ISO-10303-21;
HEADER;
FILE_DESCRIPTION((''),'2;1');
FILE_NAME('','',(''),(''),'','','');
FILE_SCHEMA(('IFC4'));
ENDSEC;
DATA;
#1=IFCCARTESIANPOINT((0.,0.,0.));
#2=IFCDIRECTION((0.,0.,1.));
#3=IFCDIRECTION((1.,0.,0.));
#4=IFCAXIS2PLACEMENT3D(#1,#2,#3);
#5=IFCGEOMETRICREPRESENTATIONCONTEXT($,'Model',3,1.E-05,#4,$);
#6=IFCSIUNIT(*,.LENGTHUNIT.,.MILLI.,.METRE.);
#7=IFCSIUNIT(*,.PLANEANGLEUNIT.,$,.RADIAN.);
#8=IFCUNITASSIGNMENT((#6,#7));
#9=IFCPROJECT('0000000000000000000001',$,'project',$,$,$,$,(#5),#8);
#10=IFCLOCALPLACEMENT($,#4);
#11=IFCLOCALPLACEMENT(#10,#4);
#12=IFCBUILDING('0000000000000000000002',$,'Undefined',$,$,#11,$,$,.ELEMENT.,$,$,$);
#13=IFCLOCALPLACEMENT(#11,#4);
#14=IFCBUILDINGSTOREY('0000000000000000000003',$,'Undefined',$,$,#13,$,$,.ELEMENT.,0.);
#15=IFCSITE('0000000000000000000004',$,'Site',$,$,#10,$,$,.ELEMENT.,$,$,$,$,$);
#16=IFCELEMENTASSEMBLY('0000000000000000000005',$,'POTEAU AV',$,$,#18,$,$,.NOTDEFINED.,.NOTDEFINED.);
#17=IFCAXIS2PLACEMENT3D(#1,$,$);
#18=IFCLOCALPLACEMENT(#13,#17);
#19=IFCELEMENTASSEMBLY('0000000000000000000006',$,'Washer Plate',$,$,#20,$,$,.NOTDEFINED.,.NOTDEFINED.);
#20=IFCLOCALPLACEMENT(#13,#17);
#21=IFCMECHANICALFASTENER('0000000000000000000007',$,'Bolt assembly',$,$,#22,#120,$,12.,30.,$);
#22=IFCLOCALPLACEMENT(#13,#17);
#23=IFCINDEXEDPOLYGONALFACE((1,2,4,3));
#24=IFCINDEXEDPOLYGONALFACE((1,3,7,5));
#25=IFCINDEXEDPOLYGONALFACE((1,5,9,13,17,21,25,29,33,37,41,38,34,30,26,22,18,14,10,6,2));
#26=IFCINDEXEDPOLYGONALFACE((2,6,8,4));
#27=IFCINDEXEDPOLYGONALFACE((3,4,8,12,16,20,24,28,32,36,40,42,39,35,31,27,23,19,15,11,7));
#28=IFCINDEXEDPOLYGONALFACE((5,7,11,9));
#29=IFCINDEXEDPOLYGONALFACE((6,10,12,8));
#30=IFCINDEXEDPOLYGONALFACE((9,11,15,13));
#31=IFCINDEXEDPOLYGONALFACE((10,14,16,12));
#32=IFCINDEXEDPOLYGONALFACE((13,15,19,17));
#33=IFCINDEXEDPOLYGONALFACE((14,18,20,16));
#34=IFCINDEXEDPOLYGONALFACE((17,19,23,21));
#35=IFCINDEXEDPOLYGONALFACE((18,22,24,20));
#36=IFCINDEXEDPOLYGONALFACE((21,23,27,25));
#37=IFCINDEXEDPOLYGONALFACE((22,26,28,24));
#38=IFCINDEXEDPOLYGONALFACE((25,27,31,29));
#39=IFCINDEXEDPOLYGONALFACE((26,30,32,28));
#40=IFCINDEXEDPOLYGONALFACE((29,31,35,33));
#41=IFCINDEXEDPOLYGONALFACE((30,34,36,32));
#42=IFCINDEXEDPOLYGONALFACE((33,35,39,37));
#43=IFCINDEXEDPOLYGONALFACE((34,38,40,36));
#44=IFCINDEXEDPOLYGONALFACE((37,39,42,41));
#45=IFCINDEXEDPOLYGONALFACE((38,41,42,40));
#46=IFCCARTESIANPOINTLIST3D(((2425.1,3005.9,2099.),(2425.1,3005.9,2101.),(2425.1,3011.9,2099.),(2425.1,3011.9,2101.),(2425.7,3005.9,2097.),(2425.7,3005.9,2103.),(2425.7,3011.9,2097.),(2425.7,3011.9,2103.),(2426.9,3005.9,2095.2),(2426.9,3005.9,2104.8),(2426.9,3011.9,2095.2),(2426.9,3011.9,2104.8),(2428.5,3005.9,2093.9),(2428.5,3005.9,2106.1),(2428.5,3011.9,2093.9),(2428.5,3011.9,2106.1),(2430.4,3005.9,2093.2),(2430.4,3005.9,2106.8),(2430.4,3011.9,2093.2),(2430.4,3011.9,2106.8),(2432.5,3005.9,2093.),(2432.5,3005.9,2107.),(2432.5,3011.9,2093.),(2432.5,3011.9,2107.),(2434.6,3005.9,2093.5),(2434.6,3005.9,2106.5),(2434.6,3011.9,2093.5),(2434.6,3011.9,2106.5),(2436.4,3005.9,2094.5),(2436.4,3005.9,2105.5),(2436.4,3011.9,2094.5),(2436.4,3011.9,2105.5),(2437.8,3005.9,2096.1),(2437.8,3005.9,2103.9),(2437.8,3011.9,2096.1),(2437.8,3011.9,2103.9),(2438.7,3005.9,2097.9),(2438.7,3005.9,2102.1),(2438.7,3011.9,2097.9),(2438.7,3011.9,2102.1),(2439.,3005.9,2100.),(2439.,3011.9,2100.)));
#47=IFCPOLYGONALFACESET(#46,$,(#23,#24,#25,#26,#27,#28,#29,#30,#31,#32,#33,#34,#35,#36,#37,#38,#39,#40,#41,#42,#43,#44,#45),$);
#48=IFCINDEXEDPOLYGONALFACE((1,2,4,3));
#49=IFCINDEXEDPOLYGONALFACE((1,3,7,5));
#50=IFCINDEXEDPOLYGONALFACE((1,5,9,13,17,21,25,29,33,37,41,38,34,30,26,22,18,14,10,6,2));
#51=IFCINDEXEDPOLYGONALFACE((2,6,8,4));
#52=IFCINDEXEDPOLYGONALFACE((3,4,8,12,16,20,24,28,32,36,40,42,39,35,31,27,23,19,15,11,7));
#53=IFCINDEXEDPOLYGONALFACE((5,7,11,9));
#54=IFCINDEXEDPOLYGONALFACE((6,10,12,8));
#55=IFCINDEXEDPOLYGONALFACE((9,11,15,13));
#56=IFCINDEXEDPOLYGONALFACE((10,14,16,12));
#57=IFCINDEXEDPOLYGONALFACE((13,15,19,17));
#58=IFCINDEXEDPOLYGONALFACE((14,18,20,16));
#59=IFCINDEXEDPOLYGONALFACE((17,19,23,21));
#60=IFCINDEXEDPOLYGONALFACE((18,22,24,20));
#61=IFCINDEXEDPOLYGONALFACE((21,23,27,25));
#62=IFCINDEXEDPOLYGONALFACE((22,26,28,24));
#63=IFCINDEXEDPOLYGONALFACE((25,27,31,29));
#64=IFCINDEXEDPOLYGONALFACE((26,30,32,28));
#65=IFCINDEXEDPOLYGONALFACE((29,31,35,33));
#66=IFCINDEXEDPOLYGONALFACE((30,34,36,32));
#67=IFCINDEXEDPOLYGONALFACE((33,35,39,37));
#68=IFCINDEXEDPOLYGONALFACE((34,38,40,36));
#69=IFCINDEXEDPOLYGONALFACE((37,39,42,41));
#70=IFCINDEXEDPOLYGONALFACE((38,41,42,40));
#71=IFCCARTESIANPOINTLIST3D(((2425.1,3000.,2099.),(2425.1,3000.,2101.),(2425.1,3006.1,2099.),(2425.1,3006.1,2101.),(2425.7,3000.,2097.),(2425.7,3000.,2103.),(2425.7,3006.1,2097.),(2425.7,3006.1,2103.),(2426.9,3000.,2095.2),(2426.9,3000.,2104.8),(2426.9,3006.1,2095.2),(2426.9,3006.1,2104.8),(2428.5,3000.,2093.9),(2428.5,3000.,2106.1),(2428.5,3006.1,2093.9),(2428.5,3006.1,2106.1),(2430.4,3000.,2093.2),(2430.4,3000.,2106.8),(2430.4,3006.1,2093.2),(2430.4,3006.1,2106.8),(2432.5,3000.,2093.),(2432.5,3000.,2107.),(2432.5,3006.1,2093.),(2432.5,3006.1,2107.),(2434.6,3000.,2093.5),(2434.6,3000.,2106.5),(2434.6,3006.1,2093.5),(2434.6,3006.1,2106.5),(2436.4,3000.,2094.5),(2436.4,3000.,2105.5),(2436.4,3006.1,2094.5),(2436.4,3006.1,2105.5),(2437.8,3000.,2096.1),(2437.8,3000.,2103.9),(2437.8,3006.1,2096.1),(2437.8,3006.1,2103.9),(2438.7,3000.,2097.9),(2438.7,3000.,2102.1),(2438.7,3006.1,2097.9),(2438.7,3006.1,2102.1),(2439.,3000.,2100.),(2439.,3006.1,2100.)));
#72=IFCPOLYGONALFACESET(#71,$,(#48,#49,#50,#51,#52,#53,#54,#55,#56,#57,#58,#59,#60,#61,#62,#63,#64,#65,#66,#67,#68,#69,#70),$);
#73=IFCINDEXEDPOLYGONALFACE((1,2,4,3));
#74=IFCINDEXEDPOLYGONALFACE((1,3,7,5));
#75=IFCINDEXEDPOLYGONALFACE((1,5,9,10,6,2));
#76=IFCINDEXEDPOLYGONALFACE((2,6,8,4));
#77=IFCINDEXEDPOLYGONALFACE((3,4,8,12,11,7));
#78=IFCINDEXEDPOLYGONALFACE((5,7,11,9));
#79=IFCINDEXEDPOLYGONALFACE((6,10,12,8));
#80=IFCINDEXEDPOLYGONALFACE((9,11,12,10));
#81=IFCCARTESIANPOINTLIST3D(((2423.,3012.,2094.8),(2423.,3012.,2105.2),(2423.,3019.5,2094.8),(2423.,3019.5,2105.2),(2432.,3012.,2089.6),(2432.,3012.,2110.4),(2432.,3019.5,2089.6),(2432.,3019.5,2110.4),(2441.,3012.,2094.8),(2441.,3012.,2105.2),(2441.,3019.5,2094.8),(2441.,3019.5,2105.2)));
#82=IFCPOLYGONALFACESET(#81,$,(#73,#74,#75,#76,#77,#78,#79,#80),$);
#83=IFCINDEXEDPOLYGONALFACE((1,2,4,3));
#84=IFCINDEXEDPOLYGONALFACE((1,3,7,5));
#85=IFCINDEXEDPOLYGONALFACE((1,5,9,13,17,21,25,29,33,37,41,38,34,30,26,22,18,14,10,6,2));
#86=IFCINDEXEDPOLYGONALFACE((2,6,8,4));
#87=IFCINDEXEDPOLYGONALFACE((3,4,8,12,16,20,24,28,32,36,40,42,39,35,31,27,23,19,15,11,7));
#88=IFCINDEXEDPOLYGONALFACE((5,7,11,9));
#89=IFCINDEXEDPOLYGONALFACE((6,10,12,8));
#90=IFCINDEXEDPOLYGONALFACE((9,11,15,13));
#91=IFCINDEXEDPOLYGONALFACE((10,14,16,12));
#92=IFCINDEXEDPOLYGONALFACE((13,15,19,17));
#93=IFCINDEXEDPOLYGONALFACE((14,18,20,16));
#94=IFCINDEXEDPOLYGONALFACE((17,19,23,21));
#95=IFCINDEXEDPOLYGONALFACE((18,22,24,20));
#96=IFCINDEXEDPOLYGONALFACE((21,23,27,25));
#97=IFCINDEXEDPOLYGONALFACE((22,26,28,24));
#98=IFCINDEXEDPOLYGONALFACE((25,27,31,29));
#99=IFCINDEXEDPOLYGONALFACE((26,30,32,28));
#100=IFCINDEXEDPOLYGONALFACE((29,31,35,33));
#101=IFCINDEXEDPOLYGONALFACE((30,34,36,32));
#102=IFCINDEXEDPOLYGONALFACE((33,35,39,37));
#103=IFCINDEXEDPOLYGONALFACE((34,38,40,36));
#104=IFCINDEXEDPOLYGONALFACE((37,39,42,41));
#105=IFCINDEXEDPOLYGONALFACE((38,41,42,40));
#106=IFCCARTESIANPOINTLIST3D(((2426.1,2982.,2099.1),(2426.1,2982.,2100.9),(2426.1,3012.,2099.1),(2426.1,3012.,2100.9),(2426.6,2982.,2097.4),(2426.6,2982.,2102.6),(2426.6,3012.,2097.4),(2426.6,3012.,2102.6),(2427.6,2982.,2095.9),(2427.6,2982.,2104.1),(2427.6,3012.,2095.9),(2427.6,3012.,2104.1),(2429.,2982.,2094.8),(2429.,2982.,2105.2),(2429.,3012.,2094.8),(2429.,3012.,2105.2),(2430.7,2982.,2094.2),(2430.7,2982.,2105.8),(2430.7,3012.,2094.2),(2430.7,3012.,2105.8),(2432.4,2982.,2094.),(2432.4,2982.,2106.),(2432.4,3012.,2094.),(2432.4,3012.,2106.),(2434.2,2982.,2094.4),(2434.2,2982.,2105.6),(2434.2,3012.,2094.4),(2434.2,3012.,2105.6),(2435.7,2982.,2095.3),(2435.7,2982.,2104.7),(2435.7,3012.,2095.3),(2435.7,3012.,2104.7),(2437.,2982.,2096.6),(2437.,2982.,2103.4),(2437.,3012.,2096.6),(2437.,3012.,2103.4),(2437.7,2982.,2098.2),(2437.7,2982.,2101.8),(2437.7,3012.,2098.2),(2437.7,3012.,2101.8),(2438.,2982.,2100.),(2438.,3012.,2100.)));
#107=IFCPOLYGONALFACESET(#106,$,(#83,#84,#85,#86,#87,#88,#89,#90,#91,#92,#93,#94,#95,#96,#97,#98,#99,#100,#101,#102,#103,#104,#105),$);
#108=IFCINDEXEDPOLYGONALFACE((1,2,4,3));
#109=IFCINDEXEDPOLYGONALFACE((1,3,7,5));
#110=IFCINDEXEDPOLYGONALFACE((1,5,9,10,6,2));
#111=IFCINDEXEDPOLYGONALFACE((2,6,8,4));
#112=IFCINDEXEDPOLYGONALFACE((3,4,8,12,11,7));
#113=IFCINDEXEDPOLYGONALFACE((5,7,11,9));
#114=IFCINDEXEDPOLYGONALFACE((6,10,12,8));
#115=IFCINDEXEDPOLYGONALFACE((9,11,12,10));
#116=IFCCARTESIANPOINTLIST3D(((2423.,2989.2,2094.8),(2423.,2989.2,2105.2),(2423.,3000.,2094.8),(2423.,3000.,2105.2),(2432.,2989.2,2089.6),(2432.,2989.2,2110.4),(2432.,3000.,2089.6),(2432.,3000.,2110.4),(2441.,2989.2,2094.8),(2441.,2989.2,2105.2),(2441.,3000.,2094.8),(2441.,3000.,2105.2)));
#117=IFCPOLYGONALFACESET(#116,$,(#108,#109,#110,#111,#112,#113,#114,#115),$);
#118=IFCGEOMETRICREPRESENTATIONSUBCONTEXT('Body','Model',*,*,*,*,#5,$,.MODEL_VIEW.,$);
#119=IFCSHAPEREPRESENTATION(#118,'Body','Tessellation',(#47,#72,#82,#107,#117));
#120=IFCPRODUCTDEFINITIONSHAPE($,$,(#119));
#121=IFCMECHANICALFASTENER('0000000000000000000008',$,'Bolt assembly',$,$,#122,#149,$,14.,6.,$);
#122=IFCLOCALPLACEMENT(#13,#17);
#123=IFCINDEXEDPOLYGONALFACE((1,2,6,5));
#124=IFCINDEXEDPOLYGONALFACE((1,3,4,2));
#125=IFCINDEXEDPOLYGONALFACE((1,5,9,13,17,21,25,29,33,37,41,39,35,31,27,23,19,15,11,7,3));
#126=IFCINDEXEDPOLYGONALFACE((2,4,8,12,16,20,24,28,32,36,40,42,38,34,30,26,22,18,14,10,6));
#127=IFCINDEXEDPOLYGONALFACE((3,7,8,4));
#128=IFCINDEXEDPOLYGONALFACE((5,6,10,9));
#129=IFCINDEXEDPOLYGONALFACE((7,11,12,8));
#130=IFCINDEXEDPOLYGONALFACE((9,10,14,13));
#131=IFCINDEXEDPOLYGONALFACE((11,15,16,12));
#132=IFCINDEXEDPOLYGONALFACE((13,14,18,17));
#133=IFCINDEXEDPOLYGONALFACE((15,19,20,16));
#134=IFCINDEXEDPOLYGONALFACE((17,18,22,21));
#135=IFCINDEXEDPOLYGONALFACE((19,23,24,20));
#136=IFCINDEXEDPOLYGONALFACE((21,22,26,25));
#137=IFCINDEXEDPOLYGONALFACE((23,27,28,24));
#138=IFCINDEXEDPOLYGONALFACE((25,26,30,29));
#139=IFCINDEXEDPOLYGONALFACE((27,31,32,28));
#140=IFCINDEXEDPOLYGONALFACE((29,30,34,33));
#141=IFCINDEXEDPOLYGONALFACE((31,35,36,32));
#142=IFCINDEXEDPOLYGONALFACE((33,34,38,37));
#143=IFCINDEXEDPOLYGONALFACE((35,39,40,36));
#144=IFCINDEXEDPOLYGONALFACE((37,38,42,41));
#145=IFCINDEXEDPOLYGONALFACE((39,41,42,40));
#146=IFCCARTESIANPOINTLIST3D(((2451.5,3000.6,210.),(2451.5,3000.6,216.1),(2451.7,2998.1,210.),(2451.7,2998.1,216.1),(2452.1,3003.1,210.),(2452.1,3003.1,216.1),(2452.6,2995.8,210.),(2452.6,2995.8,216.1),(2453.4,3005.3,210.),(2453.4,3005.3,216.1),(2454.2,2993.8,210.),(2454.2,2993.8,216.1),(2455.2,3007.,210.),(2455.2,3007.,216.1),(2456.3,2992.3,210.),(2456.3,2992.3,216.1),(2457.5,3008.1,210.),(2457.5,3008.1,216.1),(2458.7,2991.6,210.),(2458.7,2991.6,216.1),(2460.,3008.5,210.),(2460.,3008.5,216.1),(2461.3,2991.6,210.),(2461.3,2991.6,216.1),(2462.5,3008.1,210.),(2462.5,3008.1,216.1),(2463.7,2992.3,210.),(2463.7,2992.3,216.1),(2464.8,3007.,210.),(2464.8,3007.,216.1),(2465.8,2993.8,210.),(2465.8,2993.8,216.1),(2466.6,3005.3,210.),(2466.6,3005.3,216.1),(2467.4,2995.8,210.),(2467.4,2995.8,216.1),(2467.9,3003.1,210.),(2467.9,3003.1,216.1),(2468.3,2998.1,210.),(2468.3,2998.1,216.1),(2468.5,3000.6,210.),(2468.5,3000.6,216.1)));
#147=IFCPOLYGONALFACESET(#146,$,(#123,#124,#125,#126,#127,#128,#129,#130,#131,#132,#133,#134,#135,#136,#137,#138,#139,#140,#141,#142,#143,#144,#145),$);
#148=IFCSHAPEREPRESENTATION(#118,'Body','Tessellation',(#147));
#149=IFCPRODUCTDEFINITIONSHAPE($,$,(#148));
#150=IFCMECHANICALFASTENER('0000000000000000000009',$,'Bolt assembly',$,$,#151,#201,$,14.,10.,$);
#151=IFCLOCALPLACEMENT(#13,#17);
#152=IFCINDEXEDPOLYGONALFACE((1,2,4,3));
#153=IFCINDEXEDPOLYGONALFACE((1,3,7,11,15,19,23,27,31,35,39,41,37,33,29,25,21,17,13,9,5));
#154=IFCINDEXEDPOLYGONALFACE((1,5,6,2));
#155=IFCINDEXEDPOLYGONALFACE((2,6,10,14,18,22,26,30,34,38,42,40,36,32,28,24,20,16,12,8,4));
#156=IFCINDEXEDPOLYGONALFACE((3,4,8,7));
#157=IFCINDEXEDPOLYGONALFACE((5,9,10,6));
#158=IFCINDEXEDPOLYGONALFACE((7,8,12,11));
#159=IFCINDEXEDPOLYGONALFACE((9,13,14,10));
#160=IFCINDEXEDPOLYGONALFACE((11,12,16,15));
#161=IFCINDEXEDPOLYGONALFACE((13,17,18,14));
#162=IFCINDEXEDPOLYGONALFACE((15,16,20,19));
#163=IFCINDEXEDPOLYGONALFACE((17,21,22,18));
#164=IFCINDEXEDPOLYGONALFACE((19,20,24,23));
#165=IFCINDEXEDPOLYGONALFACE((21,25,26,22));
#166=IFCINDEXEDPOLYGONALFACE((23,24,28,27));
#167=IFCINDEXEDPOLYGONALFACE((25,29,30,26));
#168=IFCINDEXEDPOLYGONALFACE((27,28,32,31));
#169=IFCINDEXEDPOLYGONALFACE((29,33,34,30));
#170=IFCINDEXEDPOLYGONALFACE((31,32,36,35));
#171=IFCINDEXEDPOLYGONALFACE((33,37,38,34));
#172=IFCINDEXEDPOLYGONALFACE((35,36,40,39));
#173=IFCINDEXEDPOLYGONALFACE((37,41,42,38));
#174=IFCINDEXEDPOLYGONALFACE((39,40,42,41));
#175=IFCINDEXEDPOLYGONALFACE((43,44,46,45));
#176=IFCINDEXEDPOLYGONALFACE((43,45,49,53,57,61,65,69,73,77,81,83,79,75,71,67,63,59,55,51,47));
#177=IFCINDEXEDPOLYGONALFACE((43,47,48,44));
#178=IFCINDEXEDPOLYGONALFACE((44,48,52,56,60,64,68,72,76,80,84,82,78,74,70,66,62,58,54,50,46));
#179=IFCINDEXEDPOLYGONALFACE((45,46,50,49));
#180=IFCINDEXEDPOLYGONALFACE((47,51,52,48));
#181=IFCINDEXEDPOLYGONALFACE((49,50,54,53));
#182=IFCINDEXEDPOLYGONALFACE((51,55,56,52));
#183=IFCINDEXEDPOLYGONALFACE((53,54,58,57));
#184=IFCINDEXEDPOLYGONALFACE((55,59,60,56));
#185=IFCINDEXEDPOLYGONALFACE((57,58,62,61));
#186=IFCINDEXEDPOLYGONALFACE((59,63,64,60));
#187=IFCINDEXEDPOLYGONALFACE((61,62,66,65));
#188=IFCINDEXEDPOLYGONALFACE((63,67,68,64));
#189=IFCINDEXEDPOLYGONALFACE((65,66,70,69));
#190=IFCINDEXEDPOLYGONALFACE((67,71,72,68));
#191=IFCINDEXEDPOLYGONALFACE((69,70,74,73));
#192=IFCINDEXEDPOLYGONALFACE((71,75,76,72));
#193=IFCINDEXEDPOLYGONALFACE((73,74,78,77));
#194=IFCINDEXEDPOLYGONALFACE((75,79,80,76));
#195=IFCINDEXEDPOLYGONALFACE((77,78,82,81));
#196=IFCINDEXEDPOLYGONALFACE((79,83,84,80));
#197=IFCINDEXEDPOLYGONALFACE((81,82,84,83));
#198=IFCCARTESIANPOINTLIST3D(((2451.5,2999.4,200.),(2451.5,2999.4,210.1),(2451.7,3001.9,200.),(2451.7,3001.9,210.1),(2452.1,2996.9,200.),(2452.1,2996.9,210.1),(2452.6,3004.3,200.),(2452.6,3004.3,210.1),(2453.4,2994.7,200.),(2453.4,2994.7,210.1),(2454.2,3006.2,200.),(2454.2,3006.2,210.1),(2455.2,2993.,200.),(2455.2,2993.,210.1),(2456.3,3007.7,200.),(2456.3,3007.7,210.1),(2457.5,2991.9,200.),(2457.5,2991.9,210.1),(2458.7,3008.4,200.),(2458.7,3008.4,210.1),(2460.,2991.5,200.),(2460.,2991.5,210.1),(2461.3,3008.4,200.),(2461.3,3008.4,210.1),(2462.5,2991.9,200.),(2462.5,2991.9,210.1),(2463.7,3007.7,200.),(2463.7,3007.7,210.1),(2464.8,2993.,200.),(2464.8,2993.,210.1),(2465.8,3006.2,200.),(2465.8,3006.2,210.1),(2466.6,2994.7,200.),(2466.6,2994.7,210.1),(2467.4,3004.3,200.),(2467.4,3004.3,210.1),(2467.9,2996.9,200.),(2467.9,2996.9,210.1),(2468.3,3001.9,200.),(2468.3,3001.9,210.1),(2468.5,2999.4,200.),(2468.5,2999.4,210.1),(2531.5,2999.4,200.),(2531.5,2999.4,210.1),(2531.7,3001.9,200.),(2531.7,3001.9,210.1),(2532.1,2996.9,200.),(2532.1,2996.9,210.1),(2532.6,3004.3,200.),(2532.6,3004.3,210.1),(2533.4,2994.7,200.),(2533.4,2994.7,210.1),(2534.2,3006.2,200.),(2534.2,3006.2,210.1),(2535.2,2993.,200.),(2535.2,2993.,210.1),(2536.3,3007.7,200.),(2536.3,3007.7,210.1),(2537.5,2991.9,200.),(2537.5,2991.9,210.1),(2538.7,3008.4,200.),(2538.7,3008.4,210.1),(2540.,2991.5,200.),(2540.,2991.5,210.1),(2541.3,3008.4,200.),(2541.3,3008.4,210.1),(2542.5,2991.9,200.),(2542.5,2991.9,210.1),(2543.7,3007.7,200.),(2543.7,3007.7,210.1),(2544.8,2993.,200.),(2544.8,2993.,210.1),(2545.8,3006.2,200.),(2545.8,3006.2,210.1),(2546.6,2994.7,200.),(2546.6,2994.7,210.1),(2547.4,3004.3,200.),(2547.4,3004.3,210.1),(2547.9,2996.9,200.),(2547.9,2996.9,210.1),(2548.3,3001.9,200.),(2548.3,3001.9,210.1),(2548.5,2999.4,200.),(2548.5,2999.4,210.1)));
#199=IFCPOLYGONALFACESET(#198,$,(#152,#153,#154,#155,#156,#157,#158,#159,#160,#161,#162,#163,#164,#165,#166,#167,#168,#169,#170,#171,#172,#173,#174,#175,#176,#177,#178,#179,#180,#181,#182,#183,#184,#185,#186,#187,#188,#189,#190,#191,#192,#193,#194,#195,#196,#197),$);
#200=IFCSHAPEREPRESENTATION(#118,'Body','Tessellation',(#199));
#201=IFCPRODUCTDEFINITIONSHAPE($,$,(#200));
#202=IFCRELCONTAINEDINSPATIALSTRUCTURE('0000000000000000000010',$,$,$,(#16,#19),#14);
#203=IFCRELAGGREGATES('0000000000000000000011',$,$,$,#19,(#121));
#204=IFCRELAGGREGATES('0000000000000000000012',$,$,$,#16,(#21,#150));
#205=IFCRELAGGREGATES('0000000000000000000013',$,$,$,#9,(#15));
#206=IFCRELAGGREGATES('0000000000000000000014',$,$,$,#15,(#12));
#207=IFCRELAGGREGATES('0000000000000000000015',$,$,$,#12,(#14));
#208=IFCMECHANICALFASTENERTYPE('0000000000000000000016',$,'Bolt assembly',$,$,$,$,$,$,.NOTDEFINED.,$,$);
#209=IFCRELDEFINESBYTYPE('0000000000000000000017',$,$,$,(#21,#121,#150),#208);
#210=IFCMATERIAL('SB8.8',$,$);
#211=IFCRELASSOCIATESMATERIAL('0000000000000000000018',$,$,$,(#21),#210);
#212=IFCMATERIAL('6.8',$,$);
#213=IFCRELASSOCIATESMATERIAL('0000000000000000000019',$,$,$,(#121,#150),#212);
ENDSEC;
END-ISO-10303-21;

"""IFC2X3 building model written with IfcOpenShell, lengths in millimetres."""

from ifc_helpers import new_model, si_unit, frame, origin_with_axes, origin_2d_with_axis, place, context, subcontext, project, spatial, polyline, circle, outline, extrude, source, transform, mapped, material, type_object, element, aggregate, save


model = new_model("IFC2X3")

# Units and contexts
model_context = context("Model", 3, precision=1e-05, world=origin_with_axes())
body_context = subcontext(model_context, "Body", "Model", "MODEL_VIEW")
ifc_project = project(units=[si_unit("LENGTHUNIT", "METRE", prefix="MILLI"), si_unit("PLANEANGLEUNIT", "RADIAN")], contexts=[model_context])

# Site, building, storey
site_placement = place(None, origin_with_axes())
site = spatial("IfcSite", under=ifc_project, at=site_placement, Name="Site", CompositionType="ELEMENT")
building_placement = place(site_placement, origin_with_axes())
building = spatial("IfcBuilding", under=site, at=building_placement, Name="Undefined", CompositionType="ELEMENT")
storey_placement = place(building_placement, origin_with_axes())
storey = spatial("IfcBuildingStorey", under=building, at=storey_placement, Name="Undefined", CompositionType="ELEMENT", Elevation=0.0)

# Element assembly
assembly_1_placement = place(storey_placement, origin_with_axes())
assembly_1 = element("IfcElementAssembly", 1, at=assembly_1_placement, inside=storey, Name="POTEAU AV", AssemblyPlace="NOTDEFINED", PredefinedType="NOTDEFINED")

# Element assembly
assembly_2_placement = place(storey_placement, origin_with_axes())
assembly_2 = element("IfcElementAssembly", 2, at=assembly_2_placement, inside=storey, Name="Washer Plate", AssemblyPlace="NOTDEFINED", PredefinedType="NOTDEFINED")

# Mechanical fasteners
ifc_material_1 = material(Name="SB8.8")
mechanical_fastener_type = type_object("IfcMechanicalFastenerType", Name="Bolt assembly")
shared_shape_1 = source(origin_with_axes(), body_context, "Body", "SweptSolid", [
    extrude(circle(Radius=7.0, at=origin_2d_with_axis()), frame((0.0, -8.9, 0.0), z_axis=(0.0, 1.0, 0.0), x_axis=(1.0, 0.0, 0.0)), (0.0, 0.0, 1.0), 6.0),
    extrude(circle(Radius=7.0, at=origin_2d_with_axis()), frame((0.0, -3.1, 0.0), z_axis=(0.0, 1.0, 0.0), x_axis=(1.0, 0.0, 0.0)), (0.0, 0.0, 1.0), 6.1),
    extrude(outline(polyline([(9.0, -5.2), (9.0, 5.2), (0.0, 10.4), (-9.0, 5.2), (-9.0, -5.2), (0.0, -10.4), (9.0, -5.2)])), frame((0.0, -16.5, 0.0), z_axis=(0.0, 1.0, 0.0), x_axis=(1.0, 0.0, 0.0)), (0.0, 0.0, 1.0), 7.5),
    extrude(circle(Radius=6.0, at=origin_2d_with_axis()), frame((0.0, -9.0, 0.0), z_axis=(0.0, 1.0, 0.0), x_axis=(1.0, 0.0, 0.0)), (0.0, 0.0, 1.0), 30.0),
    extrude(outline(polyline([(9.0, -5.2), (9.0, 5.2), (0.0, 10.4), (-9.0, 5.2), (-9.0, -5.2), (0.0, -10.4), (9.0, -5.2)])), frame((0.0, 3.0, 0.0), z_axis=(0.0, 1.0, 0.0), x_axis=(1.0, 0.0, 0.0)), (0.0, 0.0, 1.0), 10.8),
])
mechanical_fastener_1_placement = place(assembly_1_placement, frame((2432.0, 3003.0, 2100.0), z_axis=(0.0, 0.0, -1.0), x_axis=(1.0, 0.0, 0.0)))
mechanical_fastener_1 = element("IfcMechanicalFastener", 3, at=mechanical_fastener_1_placement, type_object=mechanical_fastener_type, material=ifc_material_1, Name="Bolt assembly", NominalDiameter=12.0, NominalLength=30.0, context=body_context, shape_type="MappedRepresentation", body=[
    mapped(shared_shape_1, transform((0.0, 0.0, 0.0))),
])
ifc_material_2 = material(Name="6.8")
shared_shape_2 = source(origin_with_axes(), body_context, "Body", "SweptSolid", [
    extrude(circle(Radius=8.5, at=origin_2d_with_axis()), frame((0.0, 0.0, 0.0), z_axis=(0.0, 1.0, 0.0), x_axis=(1.0, 0.0, 0.0)), (0.0, 0.0, 1.0), 6.1),
])
mechanical_fastener_2_placement = place(assembly_2_placement, frame((2460.0, 3000.0, 210.0), z_axis=(1.0, 0.0, 0.0), x_axis=(0.0, 1.0, 0.0)))
mechanical_fastener_2 = element("IfcMechanicalFastener", 4, at=mechanical_fastener_2_placement, type_object=mechanical_fastener_type, material=ifc_material_2, Name="Bolt assembly", NominalDiameter=14.0, NominalLength=6.0, context=body_context, shape_type="MappedRepresentation", body=[
    mapped(shared_shape_2, transform((0.0, 0.0, 0.0))),
])
aggregate(assembly_2, [mechanical_fastener_2])
shared_shape_3 = source(origin_with_axes(), body_context, "Body", "SweptSolid", [
    extrude(circle(Radius=8.5, at=origin_2d_with_axis()), frame((0.0, -10.0, 0.0), z_axis=(0.0, 1.0, 0.0), x_axis=(1.0, 0.0, 0.0)), (0.0, 0.0, 1.0), 10.1),
])
mechanical_fastener_3_placement = place(assembly_1_placement, frame((2500.0, 3048.0, 210.0), z_axis=(-1.0, 0.0, 0.0), x_axis=(0.0, -1.0, 0.0)))
mechanical_fastener_3 = element("IfcMechanicalFastener", 5, at=mechanical_fastener_3_placement, type_object=mechanical_fastener_type, material=ifc_material_2, Name="Bolt assembly", NominalDiameter=14.0, NominalLength=10.0, context=body_context, shape_type="MappedRepresentation", body=[
    mapped(shared_shape_3, transform((48.0, 0.0, -40.0))),
    mapped(shared_shape_3, transform((48.0, 0.0, 40.0))),
])
aggregate(assembly_1, [mechanical_fastener_1, mechanical_fastener_3])

save(model, "model.ifc")
